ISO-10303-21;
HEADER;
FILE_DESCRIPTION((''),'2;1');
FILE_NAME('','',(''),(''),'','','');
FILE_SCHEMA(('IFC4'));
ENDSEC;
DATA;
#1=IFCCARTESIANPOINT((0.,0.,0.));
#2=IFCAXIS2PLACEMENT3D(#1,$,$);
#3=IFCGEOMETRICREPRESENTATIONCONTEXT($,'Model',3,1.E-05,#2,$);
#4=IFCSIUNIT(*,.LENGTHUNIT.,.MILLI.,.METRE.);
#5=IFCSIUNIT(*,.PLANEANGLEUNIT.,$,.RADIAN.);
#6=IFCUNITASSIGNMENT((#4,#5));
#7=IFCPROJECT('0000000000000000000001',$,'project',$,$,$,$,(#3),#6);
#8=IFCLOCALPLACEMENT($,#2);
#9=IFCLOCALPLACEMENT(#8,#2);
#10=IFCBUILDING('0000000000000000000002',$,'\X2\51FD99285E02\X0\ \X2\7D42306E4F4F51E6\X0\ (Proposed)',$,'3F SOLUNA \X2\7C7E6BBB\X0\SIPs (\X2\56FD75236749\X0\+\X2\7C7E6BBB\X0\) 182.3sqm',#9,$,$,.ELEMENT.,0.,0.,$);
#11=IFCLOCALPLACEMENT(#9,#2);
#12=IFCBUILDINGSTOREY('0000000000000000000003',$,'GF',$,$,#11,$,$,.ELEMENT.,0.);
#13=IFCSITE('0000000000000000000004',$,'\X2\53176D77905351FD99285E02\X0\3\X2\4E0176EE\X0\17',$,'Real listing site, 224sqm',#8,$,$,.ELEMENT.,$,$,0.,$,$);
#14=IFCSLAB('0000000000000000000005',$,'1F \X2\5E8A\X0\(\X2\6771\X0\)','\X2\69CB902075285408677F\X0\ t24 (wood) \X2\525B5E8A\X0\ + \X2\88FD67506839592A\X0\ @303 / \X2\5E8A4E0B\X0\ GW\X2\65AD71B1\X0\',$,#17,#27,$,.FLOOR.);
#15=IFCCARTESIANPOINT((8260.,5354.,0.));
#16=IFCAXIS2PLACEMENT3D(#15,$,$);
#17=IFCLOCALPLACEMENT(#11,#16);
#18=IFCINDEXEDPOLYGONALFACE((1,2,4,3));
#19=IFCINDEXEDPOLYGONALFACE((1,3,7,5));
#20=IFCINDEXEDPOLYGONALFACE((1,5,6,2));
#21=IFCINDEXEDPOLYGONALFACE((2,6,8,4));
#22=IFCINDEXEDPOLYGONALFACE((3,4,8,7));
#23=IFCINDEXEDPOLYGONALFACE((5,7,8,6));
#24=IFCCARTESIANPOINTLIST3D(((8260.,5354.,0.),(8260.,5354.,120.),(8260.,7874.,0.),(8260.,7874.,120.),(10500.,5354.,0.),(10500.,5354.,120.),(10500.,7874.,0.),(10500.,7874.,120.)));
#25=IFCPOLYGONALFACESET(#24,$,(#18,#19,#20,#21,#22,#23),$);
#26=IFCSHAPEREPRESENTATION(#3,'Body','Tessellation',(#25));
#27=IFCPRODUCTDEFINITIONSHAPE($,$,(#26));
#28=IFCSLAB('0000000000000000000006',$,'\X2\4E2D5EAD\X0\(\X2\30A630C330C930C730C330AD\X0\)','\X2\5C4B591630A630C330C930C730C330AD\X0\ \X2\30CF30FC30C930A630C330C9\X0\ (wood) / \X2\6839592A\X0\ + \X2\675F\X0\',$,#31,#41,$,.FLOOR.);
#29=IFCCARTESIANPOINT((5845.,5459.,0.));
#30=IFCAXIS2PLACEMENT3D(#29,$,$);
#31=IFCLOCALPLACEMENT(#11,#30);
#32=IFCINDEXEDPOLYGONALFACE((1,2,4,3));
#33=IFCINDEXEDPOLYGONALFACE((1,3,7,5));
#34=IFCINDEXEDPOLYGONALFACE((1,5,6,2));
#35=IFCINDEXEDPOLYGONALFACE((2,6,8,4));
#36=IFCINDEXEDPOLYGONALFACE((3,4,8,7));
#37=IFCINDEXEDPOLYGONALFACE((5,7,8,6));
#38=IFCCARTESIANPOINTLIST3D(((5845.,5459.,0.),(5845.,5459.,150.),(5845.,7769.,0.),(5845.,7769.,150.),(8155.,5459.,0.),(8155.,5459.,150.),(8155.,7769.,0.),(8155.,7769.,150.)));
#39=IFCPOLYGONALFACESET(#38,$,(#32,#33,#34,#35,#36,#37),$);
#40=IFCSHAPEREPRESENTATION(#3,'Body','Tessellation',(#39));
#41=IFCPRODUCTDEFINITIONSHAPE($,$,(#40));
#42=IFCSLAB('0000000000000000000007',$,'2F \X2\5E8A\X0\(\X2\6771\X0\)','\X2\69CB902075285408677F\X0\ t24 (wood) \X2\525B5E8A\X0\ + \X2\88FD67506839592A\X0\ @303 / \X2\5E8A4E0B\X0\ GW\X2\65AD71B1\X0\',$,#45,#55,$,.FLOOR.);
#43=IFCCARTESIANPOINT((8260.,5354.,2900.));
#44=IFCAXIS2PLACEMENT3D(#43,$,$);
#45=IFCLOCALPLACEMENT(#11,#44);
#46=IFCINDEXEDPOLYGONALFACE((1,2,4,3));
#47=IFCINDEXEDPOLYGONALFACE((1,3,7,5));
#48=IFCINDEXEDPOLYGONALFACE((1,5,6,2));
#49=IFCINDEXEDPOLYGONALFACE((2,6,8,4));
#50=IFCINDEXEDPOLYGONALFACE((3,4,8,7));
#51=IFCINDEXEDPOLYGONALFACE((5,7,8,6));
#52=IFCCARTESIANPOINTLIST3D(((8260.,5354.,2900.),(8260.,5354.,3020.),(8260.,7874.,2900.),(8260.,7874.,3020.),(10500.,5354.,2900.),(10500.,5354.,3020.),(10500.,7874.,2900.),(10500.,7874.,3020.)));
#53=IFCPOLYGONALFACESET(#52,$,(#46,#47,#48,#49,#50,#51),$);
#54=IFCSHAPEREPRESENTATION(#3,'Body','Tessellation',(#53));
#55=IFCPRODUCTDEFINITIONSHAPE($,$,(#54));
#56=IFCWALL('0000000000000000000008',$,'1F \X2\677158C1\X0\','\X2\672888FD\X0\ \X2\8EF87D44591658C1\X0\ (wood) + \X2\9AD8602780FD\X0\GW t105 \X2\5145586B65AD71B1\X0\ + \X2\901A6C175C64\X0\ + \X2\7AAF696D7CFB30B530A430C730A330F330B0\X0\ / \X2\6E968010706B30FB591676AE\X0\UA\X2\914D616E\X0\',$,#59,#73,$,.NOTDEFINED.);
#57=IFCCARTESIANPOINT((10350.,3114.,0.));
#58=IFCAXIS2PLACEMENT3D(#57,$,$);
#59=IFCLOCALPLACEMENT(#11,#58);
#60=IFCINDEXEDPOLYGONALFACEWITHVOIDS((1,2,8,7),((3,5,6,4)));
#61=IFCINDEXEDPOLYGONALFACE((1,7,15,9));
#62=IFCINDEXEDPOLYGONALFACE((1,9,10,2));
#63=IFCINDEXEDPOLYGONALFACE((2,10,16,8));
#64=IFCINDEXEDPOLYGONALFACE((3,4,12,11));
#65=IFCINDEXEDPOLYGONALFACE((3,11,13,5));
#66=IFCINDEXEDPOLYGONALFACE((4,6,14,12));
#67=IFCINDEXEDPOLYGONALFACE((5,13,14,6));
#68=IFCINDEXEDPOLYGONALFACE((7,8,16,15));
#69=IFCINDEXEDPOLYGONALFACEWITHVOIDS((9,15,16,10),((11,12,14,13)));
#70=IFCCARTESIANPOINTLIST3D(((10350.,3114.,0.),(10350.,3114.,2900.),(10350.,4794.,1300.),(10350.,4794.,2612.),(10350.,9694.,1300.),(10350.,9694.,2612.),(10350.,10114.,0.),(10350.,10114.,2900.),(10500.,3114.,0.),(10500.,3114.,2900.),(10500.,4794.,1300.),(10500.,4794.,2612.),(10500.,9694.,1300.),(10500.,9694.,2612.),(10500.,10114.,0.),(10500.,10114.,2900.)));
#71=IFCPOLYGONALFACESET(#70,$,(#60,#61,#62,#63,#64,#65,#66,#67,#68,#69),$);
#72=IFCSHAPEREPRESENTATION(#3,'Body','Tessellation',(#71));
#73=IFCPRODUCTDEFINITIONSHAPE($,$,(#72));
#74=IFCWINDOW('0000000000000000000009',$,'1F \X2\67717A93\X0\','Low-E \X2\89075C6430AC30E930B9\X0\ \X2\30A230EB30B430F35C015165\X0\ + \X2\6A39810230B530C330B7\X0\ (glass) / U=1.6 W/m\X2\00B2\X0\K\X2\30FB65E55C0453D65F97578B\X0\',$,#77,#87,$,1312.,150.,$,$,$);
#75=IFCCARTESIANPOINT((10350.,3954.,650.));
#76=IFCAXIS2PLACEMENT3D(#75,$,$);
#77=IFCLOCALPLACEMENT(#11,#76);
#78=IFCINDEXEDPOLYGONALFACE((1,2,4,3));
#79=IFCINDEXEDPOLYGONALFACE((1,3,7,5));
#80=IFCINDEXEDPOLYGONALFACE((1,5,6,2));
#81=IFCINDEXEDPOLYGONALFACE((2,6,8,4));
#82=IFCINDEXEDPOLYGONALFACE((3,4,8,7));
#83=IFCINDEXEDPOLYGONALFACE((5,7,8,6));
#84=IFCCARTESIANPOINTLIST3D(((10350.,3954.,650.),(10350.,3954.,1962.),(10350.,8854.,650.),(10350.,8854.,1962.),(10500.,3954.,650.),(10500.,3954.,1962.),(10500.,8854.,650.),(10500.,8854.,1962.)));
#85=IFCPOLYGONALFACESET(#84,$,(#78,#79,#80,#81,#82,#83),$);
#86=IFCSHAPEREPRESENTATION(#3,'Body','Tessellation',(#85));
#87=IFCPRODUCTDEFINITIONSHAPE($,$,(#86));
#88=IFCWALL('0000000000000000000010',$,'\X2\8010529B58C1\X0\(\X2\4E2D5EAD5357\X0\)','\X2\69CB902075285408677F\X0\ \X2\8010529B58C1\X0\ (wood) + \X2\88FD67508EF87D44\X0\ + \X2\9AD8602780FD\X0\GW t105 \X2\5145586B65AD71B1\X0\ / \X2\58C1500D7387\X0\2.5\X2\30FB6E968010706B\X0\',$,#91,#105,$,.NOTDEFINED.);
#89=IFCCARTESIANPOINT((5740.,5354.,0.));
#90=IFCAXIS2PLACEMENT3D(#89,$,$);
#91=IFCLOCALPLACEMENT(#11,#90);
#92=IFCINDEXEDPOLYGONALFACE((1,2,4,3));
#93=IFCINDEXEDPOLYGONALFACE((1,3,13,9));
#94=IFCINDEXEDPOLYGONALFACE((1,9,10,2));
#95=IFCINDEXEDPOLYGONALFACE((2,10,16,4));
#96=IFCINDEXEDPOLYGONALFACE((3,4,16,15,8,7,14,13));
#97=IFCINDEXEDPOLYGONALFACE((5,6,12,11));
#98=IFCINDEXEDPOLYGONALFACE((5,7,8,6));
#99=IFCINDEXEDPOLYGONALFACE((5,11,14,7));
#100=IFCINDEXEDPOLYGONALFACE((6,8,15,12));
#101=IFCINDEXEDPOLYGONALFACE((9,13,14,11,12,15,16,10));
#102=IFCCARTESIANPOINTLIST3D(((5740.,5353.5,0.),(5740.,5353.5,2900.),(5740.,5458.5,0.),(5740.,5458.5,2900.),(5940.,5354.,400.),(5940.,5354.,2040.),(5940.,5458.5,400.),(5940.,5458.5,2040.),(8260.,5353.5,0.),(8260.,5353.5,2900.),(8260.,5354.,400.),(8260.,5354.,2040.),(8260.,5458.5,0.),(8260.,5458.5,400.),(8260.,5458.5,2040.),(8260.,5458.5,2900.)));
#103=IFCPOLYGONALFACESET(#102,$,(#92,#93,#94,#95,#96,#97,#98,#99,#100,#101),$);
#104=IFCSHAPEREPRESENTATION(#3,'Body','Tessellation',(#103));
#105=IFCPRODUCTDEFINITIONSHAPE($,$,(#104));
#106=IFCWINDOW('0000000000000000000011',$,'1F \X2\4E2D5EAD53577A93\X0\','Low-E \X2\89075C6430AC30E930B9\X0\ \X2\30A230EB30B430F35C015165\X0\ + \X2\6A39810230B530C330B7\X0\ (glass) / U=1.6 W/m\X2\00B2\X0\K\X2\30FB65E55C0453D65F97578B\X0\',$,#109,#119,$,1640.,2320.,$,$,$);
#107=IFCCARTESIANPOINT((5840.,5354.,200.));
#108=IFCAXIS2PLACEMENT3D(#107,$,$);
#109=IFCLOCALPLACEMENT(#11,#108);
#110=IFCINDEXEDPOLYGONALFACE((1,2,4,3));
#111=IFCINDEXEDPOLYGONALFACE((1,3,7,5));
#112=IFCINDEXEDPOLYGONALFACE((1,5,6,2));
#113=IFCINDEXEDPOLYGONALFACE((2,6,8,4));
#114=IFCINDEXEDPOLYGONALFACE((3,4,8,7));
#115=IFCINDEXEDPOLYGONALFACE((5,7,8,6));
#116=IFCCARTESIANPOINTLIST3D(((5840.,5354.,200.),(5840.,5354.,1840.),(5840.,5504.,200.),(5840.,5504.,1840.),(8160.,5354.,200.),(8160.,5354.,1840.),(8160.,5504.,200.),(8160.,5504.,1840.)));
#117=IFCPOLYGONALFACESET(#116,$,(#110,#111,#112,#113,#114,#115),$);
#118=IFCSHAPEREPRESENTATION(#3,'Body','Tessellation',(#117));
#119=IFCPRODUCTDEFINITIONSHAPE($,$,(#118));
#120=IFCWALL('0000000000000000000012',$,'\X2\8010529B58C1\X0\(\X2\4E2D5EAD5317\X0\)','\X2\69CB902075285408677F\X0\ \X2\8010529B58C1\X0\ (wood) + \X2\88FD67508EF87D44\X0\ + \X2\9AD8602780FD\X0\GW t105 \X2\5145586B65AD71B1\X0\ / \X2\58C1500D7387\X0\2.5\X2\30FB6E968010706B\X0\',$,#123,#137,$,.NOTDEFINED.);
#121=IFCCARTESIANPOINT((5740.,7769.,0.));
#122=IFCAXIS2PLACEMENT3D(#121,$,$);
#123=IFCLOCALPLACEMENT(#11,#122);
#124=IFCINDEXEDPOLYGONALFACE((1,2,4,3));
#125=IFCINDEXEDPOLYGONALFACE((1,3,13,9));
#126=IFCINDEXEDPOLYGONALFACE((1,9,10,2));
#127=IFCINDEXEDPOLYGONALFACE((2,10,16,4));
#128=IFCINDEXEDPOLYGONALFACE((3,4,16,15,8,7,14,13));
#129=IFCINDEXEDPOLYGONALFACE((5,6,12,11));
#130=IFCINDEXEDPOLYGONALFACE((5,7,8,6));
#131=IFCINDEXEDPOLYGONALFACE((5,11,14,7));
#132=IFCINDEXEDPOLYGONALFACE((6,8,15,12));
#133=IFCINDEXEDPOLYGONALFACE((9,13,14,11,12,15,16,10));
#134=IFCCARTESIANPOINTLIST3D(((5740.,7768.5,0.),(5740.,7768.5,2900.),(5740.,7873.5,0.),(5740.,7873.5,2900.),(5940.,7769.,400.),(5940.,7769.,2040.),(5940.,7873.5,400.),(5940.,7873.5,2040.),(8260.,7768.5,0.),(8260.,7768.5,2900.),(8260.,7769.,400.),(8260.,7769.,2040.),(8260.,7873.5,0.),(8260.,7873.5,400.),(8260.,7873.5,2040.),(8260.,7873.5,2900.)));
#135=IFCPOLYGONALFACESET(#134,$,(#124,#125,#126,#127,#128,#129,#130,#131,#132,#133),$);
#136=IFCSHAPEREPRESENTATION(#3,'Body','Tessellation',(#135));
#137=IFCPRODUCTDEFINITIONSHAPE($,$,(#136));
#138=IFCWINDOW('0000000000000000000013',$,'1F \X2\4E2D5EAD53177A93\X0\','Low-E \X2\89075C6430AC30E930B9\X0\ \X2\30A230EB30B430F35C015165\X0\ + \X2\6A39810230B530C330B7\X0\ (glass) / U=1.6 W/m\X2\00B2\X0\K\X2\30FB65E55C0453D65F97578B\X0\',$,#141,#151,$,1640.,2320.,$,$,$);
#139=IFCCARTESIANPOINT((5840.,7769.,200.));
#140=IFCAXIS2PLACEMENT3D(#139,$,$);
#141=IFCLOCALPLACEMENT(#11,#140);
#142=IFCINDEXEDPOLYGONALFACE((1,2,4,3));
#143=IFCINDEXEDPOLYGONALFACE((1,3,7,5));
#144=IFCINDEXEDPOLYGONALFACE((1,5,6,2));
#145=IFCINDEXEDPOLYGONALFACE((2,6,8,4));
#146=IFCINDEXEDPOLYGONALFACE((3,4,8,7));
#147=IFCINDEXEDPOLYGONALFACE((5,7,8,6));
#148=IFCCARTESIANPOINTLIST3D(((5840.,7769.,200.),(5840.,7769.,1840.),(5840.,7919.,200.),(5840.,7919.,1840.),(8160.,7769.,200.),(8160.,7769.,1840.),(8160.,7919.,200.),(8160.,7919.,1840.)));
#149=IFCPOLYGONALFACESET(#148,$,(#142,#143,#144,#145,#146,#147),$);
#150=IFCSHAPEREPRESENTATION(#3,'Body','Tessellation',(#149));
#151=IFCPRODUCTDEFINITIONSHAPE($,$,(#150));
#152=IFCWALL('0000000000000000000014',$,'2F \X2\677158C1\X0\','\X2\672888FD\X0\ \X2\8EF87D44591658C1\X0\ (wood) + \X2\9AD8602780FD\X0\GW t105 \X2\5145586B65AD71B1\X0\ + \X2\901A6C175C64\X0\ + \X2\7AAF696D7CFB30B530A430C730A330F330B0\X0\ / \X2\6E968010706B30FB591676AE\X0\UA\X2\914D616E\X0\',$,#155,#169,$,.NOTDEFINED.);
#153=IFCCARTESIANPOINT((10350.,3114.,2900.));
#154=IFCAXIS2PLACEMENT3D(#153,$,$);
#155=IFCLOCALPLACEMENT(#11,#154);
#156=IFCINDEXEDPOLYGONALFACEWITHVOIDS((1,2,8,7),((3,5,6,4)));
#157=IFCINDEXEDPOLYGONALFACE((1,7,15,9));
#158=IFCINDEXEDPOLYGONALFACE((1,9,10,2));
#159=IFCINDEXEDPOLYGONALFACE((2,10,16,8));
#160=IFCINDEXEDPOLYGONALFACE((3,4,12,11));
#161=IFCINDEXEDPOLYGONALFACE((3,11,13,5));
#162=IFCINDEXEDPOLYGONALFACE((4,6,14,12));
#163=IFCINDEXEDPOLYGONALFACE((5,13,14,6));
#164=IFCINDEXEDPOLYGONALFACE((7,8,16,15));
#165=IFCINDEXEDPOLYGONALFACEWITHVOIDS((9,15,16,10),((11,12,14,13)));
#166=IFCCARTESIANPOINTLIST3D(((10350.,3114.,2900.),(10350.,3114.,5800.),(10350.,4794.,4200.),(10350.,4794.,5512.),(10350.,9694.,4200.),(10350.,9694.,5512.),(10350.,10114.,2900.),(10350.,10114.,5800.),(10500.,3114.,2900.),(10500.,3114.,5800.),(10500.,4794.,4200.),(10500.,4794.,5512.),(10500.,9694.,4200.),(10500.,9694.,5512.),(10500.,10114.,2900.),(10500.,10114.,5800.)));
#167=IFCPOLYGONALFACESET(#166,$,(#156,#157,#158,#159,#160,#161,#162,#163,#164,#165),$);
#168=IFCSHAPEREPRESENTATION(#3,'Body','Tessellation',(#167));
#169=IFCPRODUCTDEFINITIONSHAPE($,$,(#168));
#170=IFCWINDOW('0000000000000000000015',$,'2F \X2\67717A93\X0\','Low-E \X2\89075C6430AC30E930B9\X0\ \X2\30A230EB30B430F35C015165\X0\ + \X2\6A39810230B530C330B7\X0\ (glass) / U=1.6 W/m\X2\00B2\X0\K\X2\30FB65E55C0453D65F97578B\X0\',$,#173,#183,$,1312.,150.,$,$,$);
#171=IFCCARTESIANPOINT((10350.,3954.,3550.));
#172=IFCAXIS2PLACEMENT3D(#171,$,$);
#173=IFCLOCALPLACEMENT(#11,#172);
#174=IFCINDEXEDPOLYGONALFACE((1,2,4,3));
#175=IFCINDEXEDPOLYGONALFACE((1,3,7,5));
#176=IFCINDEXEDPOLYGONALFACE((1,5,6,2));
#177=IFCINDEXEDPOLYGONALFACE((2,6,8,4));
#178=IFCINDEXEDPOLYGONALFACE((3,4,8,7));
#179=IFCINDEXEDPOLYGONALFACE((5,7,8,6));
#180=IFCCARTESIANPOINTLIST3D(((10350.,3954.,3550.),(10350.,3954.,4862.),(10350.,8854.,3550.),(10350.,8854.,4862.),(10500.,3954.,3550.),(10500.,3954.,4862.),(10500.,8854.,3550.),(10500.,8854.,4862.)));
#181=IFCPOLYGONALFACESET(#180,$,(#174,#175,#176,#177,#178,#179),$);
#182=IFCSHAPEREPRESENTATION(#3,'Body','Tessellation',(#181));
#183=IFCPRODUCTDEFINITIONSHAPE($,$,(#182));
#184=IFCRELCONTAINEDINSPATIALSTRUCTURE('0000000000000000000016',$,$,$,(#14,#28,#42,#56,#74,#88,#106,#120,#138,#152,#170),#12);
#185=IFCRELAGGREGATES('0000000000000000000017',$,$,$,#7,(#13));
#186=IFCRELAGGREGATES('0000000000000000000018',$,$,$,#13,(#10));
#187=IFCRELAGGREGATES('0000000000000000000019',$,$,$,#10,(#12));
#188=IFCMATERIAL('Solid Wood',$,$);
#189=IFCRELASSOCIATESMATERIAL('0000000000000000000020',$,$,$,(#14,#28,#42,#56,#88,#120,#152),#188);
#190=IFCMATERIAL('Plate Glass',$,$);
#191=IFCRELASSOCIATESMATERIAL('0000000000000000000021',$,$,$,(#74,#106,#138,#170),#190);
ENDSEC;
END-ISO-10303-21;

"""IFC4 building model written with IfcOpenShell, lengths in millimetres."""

from ifc_helpers import new_model, si_unit, frame, frame_2d, origin, place, context, project, spatial, rectangle, extrude, material, element, fill, save


model = new_model("IFC4")

# Units and contexts
model_context = context("Model", 3, precision=1e-05, world=origin())
ifc_project = project(units=[si_unit("LENGTHUNIT", "METRE", prefix="MILLI"), si_unit("PLANEANGLEUNIT", "RADIAN")], contexts=[model_context])

# Site, building, storey
site_placement = place(None, origin())
site = spatial("IfcSite", under=ifc_project, at=site_placement, Name="北海道函館市3丁目17", ObjectType="Real listing site, 224sqm", CompositionType="ELEMENT", RefElevation=0.0)
building_placement = place(site_placement, origin())
building = spatial("IfcBuilding", under=site, at=building_placement, Name="函館市 終の住処 (Proposed)", ObjectType="3F SOLUNA 籾殻SIPs (国産杉+籾殻) 182.3sqm", CompositionType="ELEMENT", ElevationOfRefHeight=0.0, ElevationOfTerrain=0.0)
storey_placement = place(building_placement, origin())
storey = spatial("IfcBuildingStorey", under=building, at=storey_placement, Name="GF", CompositionType="ELEMENT", Elevation=0.0)

# Slabs
ifc_material_1 = material(Name="Solid Wood")
slab_1_placement = place(storey_placement, frame((8260.0, 5354.0, 0.0)))
element("IfcSlab", 1, at=slab_1_placement, inside=storey, material=ifc_material_1, Name="1F 床(東)", Description="構造用合板 t24 (wood) 剛床 + 製材根太 @303 / 床下 GW断熱", PredefinedType="FLOOR", context=model_context, shape_type="SweptSolid", body=[
    extrude(rectangle(XDim=2240.0, YDim=2520.0, at=frame_2d((1120.0, 1260.0))), frame((8260.0, 5354.0, 0.0)), (0.0, 0.0, 1.0), 120.0),
])
slab_2_placement = place(storey_placement, frame((5845.0, 5459.0, 0.0)))
element("IfcSlab", 2, at=slab_2_placement, inside=storey, material=ifc_material_1, Name="中庭(ウッドデッキ)", Description="屋外ウッドデッキ ハードウッド (wood) / 根太 + 束", PredefinedType="FLOOR", context=model_context, shape_type="SweptSolid", body=[
    extrude(rectangle(XDim=2310.0, YDim=2310.0, at=frame_2d((1155.0, 1155.0))), frame((5845.0, 5459.0, 0.0)), (0.0, 0.0, 1.0), 150.0),
])
slab_3_placement = place(storey_placement, frame((8260.0, 5354.0, 2900.0)))
element("IfcSlab", 3, at=slab_3_placement, inside=storey, material=ifc_material_1, Name="2F 床(東)", Description="構造用合板 t24 (wood) 剛床 + 製材根太 @303 / 床下 GW断熱", PredefinedType="FLOOR", context=model_context, shape_type="SweptSolid", body=[
    extrude(rectangle(XDim=2240.0, YDim=2520.0, at=frame_2d((1120.0, 1260.0))), frame((8260.0, 5354.0, 2900.0)), (0.0, 0.0, 1.0), 120.0),
])

# Walls, openings, windows
wall_1_placement = place(storey_placement, frame((10350.0, 3114.0, 0.0)))
wall_1 = element("IfcWall", 4, at=wall_1_placement, inside=storey, material=ifc_material_1, Name="1F 東壁", Description="木製 軸組外壁 (wood) + 高性能GW t105 充填断熱 + 通気層 + 窯業系サイディング / 準耐火・外皮UA配慮", PredefinedType="NOTDEFINED", context=model_context, shape_type="SweptSolid", body=[
    extrude(rectangle(XDim=150.0, YDim=7000.0, at=frame_2d((75.0, 3500.0))), frame((10350.0, 3114.0, 0.0)), (0.0, 0.0, 1.0), 2900.0),
])
opening_1_placement = place(storey_placement, frame((10350.0, 3954.0, 650.0)))
opening_1 = element("IfcOpeningElement", 5, at=opening_1_placement, cuts=wall_1, PredefinedType="NOTDEFINED", context=model_context, shape_type="SweptSolid", body=[
    extrude(rectangle(XDim=150.0, YDim=4900.0, at=frame_2d((75.0, 2450.0))), frame((10350.0, 3954.0, 650.0)), (0.0, 0.0, 1.0), 1312.0),
])
ifc_material_2 = material(Name="Plate Glass")
window_1_placement = place(storey_placement, frame((10350.0, 3954.0, 650.0)))
window_1 = element("IfcWindow", 6, at=window_1_placement, inside=storey, material=ifc_material_2, Name="1F 東窓", Description="Low-E 複層ガラス アルゴン封入 + 樹脂サッシ (glass) / U=1.6 W/m²K・日射取得型", OverallHeight=1312.0, OverallWidth=150.0, context=model_context, shape_type="SweptSolid", body=[
    extrude(rectangle(XDim=150.0, YDim=4900.0, at=frame_2d((75.0, 2450.0))), frame((10350.0, 3954.0, 650.0)), (0.0, 0.0, 1.0), 1312.0),
])
fill(opening_1, window_1)
wall_2_placement = place(storey_placement, frame((5740.0, 5354.0, 0.0)))
wall_2 = element("IfcWall", 7, at=wall_2_placement, inside=storey, material=ifc_material_1, Name="耐力壁(中庭南)", Description="構造用合板 耐力壁 (wood) + 製材軸組 + 高性能GW t105 充填断熱 / 壁倍率2.5・準耐火", PredefinedType="NOTDEFINED", context=model_context, shape_type="SweptSolid", body=[
    extrude(rectangle(XDim=2520.0, YDim=105.0, at=frame_2d((1260.0, 52.0))), frame((5740.0, 5354.0, 0.0)), (0.0, 0.0, 1.0), 2900.0),
])
opening_2_placement = place(storey_placement, frame((5840.0, 5354.0, 200.0)))
opening_2 = element("IfcOpeningElement", 8, at=opening_2_placement, cuts=wall_2, PredefinedType="NOTDEFINED", context=model_context, shape_type="SweptSolid", body=[
    extrude(rectangle(XDim=2320.0, YDim=150.0, at=frame_2d((1160.0, 75.0))), frame((5840.0, 5354.0, 200.0)), (0.0, 0.0, 1.0), 1640.0),
])
window_2_placement = place(storey_placement, frame((5840.0, 5354.0, 200.0)))
window_2 = element("IfcWindow", 9, at=window_2_placement, inside=storey, material=ifc_material_2, Name="1F 中庭南窓", Description="Low-E 複層ガラス アルゴン封入 + 樹脂サッシ (glass) / U=1.6 W/m²K・日射取得型", OverallHeight=1640.0, OverallWidth=2320.0, context=model_context, shape_type="SweptSolid", body=[
    extrude(rectangle(XDim=2320.0, YDim=150.0, at=frame_2d((1160.0, 75.0))), frame((5840.0, 5354.0, 200.0)), (0.0, 0.0, 1.0), 1640.0),
])
fill(opening_2, window_2)
wall_3_placement = place(storey_placement, frame((5740.0, 7769.0, 0.0)))
wall_3 = element("IfcWall", 10, at=wall_3_placement, inside=storey, material=ifc_material_1, Name="耐力壁(中庭北)", Description="構造用合板 耐力壁 (wood) + 製材軸組 + 高性能GW t105 充填断熱 / 壁倍率2.5・準耐火", PredefinedType="NOTDEFINED", context=model_context, shape_type="SweptSolid", body=[
    extrude(rectangle(XDim=2520.0, YDim=105.0, at=frame_2d((1260.0, 52.0))), frame((5740.0, 7769.0, 0.0)), (0.0, 0.0, 1.0), 2900.0),
])
opening_3_placement = place(storey_placement, frame((5840.0, 7769.0, 200.0)))
opening_3 = element("IfcOpeningElement", 11, at=opening_3_placement, cuts=wall_3, PredefinedType="NOTDEFINED", context=model_context, shape_type="SweptSolid", body=[
    extrude(rectangle(XDim=2320.0, YDim=150.0, at=frame_2d((1160.0, 75.0))), frame((5840.0, 7769.0, 200.0)), (0.0, 0.0, 1.0), 1640.0),
])
window_3_placement = place(storey_placement, frame((5840.0, 7769.0, 200.0)))
window_3 = element("IfcWindow", 12, at=window_3_placement, inside=storey, material=ifc_material_2, Name="1F 中庭北窓", Description="Low-E 複層ガラス アルゴン封入 + 樹脂サッシ (glass) / U=1.6 W/m²K・日射取得型", OverallHeight=1640.0, OverallWidth=2320.0, context=model_context, shape_type="SweptSolid", body=[
    extrude(rectangle(XDim=2320.0, YDim=150.0, at=frame_2d((1160.0, 75.0))), frame((5840.0, 7769.0, 200.0)), (0.0, 0.0, 1.0), 1640.0),
])
fill(opening_3, window_3)

# Wall, opening, window
wall_4_placement = place(storey_placement, frame((10350.0, 3114.0, 2900.0)))
wall_4 = element("IfcWall", 13, at=wall_4_placement, inside=storey, material=ifc_material_1, Name="2F 東壁", Description="木製 軸組外壁 (wood) + 高性能GW t105 充填断熱 + 通気層 + 窯業系サイディング / 準耐火・外皮UA配慮", PredefinedType="NOTDEFINED", context=model_context, shape_type="SweptSolid", body=[
    extrude(rectangle(XDim=150.0, YDim=7000.0, at=frame_2d((75.0, 3500.0))), frame((10350.0, 3114.0, 2900.0)), (0.0, 0.0, 1.0), 2900.0),
])
opening_4_placement = place(storey_placement, frame((10350.0, 3954.0, 3550.0)))
opening_4 = element("IfcOpeningElement", 14, at=opening_4_placement, cuts=wall_4, PredefinedType="NOTDEFINED", context=model_context, shape_type="SweptSolid", body=[
    extrude(rectangle(XDim=150.0, YDim=4900.0, at=frame_2d((75.0, 2450.0))), frame((10350.0, 3954.0, 3550.0)), (0.0, 0.0, 1.0), 1312.0),
])
window_4_placement = place(storey_placement, frame((10350.0, 3954.0, 3550.0)))
window_4 = element("IfcWindow", 15, at=window_4_placement, inside=storey, material=ifc_material_2, Name="2F 東窓", Description="Low-E 複層ガラス アルゴン封入 + 樹脂サッシ (glass) / U=1.6 W/m²K・日射取得型", OverallHeight=1312.0, OverallWidth=150.0, context=model_context, shape_type="SweptSolid", body=[
    extrude(rectangle(XDim=150.0, YDim=4900.0, at=frame_2d((75.0, 2450.0))), frame((10350.0, 3954.0, 3550.0)), (0.0, 0.0, 1.0), 1312.0),
])
fill(opening_4, window_4)

save(model, "model.ifc")
